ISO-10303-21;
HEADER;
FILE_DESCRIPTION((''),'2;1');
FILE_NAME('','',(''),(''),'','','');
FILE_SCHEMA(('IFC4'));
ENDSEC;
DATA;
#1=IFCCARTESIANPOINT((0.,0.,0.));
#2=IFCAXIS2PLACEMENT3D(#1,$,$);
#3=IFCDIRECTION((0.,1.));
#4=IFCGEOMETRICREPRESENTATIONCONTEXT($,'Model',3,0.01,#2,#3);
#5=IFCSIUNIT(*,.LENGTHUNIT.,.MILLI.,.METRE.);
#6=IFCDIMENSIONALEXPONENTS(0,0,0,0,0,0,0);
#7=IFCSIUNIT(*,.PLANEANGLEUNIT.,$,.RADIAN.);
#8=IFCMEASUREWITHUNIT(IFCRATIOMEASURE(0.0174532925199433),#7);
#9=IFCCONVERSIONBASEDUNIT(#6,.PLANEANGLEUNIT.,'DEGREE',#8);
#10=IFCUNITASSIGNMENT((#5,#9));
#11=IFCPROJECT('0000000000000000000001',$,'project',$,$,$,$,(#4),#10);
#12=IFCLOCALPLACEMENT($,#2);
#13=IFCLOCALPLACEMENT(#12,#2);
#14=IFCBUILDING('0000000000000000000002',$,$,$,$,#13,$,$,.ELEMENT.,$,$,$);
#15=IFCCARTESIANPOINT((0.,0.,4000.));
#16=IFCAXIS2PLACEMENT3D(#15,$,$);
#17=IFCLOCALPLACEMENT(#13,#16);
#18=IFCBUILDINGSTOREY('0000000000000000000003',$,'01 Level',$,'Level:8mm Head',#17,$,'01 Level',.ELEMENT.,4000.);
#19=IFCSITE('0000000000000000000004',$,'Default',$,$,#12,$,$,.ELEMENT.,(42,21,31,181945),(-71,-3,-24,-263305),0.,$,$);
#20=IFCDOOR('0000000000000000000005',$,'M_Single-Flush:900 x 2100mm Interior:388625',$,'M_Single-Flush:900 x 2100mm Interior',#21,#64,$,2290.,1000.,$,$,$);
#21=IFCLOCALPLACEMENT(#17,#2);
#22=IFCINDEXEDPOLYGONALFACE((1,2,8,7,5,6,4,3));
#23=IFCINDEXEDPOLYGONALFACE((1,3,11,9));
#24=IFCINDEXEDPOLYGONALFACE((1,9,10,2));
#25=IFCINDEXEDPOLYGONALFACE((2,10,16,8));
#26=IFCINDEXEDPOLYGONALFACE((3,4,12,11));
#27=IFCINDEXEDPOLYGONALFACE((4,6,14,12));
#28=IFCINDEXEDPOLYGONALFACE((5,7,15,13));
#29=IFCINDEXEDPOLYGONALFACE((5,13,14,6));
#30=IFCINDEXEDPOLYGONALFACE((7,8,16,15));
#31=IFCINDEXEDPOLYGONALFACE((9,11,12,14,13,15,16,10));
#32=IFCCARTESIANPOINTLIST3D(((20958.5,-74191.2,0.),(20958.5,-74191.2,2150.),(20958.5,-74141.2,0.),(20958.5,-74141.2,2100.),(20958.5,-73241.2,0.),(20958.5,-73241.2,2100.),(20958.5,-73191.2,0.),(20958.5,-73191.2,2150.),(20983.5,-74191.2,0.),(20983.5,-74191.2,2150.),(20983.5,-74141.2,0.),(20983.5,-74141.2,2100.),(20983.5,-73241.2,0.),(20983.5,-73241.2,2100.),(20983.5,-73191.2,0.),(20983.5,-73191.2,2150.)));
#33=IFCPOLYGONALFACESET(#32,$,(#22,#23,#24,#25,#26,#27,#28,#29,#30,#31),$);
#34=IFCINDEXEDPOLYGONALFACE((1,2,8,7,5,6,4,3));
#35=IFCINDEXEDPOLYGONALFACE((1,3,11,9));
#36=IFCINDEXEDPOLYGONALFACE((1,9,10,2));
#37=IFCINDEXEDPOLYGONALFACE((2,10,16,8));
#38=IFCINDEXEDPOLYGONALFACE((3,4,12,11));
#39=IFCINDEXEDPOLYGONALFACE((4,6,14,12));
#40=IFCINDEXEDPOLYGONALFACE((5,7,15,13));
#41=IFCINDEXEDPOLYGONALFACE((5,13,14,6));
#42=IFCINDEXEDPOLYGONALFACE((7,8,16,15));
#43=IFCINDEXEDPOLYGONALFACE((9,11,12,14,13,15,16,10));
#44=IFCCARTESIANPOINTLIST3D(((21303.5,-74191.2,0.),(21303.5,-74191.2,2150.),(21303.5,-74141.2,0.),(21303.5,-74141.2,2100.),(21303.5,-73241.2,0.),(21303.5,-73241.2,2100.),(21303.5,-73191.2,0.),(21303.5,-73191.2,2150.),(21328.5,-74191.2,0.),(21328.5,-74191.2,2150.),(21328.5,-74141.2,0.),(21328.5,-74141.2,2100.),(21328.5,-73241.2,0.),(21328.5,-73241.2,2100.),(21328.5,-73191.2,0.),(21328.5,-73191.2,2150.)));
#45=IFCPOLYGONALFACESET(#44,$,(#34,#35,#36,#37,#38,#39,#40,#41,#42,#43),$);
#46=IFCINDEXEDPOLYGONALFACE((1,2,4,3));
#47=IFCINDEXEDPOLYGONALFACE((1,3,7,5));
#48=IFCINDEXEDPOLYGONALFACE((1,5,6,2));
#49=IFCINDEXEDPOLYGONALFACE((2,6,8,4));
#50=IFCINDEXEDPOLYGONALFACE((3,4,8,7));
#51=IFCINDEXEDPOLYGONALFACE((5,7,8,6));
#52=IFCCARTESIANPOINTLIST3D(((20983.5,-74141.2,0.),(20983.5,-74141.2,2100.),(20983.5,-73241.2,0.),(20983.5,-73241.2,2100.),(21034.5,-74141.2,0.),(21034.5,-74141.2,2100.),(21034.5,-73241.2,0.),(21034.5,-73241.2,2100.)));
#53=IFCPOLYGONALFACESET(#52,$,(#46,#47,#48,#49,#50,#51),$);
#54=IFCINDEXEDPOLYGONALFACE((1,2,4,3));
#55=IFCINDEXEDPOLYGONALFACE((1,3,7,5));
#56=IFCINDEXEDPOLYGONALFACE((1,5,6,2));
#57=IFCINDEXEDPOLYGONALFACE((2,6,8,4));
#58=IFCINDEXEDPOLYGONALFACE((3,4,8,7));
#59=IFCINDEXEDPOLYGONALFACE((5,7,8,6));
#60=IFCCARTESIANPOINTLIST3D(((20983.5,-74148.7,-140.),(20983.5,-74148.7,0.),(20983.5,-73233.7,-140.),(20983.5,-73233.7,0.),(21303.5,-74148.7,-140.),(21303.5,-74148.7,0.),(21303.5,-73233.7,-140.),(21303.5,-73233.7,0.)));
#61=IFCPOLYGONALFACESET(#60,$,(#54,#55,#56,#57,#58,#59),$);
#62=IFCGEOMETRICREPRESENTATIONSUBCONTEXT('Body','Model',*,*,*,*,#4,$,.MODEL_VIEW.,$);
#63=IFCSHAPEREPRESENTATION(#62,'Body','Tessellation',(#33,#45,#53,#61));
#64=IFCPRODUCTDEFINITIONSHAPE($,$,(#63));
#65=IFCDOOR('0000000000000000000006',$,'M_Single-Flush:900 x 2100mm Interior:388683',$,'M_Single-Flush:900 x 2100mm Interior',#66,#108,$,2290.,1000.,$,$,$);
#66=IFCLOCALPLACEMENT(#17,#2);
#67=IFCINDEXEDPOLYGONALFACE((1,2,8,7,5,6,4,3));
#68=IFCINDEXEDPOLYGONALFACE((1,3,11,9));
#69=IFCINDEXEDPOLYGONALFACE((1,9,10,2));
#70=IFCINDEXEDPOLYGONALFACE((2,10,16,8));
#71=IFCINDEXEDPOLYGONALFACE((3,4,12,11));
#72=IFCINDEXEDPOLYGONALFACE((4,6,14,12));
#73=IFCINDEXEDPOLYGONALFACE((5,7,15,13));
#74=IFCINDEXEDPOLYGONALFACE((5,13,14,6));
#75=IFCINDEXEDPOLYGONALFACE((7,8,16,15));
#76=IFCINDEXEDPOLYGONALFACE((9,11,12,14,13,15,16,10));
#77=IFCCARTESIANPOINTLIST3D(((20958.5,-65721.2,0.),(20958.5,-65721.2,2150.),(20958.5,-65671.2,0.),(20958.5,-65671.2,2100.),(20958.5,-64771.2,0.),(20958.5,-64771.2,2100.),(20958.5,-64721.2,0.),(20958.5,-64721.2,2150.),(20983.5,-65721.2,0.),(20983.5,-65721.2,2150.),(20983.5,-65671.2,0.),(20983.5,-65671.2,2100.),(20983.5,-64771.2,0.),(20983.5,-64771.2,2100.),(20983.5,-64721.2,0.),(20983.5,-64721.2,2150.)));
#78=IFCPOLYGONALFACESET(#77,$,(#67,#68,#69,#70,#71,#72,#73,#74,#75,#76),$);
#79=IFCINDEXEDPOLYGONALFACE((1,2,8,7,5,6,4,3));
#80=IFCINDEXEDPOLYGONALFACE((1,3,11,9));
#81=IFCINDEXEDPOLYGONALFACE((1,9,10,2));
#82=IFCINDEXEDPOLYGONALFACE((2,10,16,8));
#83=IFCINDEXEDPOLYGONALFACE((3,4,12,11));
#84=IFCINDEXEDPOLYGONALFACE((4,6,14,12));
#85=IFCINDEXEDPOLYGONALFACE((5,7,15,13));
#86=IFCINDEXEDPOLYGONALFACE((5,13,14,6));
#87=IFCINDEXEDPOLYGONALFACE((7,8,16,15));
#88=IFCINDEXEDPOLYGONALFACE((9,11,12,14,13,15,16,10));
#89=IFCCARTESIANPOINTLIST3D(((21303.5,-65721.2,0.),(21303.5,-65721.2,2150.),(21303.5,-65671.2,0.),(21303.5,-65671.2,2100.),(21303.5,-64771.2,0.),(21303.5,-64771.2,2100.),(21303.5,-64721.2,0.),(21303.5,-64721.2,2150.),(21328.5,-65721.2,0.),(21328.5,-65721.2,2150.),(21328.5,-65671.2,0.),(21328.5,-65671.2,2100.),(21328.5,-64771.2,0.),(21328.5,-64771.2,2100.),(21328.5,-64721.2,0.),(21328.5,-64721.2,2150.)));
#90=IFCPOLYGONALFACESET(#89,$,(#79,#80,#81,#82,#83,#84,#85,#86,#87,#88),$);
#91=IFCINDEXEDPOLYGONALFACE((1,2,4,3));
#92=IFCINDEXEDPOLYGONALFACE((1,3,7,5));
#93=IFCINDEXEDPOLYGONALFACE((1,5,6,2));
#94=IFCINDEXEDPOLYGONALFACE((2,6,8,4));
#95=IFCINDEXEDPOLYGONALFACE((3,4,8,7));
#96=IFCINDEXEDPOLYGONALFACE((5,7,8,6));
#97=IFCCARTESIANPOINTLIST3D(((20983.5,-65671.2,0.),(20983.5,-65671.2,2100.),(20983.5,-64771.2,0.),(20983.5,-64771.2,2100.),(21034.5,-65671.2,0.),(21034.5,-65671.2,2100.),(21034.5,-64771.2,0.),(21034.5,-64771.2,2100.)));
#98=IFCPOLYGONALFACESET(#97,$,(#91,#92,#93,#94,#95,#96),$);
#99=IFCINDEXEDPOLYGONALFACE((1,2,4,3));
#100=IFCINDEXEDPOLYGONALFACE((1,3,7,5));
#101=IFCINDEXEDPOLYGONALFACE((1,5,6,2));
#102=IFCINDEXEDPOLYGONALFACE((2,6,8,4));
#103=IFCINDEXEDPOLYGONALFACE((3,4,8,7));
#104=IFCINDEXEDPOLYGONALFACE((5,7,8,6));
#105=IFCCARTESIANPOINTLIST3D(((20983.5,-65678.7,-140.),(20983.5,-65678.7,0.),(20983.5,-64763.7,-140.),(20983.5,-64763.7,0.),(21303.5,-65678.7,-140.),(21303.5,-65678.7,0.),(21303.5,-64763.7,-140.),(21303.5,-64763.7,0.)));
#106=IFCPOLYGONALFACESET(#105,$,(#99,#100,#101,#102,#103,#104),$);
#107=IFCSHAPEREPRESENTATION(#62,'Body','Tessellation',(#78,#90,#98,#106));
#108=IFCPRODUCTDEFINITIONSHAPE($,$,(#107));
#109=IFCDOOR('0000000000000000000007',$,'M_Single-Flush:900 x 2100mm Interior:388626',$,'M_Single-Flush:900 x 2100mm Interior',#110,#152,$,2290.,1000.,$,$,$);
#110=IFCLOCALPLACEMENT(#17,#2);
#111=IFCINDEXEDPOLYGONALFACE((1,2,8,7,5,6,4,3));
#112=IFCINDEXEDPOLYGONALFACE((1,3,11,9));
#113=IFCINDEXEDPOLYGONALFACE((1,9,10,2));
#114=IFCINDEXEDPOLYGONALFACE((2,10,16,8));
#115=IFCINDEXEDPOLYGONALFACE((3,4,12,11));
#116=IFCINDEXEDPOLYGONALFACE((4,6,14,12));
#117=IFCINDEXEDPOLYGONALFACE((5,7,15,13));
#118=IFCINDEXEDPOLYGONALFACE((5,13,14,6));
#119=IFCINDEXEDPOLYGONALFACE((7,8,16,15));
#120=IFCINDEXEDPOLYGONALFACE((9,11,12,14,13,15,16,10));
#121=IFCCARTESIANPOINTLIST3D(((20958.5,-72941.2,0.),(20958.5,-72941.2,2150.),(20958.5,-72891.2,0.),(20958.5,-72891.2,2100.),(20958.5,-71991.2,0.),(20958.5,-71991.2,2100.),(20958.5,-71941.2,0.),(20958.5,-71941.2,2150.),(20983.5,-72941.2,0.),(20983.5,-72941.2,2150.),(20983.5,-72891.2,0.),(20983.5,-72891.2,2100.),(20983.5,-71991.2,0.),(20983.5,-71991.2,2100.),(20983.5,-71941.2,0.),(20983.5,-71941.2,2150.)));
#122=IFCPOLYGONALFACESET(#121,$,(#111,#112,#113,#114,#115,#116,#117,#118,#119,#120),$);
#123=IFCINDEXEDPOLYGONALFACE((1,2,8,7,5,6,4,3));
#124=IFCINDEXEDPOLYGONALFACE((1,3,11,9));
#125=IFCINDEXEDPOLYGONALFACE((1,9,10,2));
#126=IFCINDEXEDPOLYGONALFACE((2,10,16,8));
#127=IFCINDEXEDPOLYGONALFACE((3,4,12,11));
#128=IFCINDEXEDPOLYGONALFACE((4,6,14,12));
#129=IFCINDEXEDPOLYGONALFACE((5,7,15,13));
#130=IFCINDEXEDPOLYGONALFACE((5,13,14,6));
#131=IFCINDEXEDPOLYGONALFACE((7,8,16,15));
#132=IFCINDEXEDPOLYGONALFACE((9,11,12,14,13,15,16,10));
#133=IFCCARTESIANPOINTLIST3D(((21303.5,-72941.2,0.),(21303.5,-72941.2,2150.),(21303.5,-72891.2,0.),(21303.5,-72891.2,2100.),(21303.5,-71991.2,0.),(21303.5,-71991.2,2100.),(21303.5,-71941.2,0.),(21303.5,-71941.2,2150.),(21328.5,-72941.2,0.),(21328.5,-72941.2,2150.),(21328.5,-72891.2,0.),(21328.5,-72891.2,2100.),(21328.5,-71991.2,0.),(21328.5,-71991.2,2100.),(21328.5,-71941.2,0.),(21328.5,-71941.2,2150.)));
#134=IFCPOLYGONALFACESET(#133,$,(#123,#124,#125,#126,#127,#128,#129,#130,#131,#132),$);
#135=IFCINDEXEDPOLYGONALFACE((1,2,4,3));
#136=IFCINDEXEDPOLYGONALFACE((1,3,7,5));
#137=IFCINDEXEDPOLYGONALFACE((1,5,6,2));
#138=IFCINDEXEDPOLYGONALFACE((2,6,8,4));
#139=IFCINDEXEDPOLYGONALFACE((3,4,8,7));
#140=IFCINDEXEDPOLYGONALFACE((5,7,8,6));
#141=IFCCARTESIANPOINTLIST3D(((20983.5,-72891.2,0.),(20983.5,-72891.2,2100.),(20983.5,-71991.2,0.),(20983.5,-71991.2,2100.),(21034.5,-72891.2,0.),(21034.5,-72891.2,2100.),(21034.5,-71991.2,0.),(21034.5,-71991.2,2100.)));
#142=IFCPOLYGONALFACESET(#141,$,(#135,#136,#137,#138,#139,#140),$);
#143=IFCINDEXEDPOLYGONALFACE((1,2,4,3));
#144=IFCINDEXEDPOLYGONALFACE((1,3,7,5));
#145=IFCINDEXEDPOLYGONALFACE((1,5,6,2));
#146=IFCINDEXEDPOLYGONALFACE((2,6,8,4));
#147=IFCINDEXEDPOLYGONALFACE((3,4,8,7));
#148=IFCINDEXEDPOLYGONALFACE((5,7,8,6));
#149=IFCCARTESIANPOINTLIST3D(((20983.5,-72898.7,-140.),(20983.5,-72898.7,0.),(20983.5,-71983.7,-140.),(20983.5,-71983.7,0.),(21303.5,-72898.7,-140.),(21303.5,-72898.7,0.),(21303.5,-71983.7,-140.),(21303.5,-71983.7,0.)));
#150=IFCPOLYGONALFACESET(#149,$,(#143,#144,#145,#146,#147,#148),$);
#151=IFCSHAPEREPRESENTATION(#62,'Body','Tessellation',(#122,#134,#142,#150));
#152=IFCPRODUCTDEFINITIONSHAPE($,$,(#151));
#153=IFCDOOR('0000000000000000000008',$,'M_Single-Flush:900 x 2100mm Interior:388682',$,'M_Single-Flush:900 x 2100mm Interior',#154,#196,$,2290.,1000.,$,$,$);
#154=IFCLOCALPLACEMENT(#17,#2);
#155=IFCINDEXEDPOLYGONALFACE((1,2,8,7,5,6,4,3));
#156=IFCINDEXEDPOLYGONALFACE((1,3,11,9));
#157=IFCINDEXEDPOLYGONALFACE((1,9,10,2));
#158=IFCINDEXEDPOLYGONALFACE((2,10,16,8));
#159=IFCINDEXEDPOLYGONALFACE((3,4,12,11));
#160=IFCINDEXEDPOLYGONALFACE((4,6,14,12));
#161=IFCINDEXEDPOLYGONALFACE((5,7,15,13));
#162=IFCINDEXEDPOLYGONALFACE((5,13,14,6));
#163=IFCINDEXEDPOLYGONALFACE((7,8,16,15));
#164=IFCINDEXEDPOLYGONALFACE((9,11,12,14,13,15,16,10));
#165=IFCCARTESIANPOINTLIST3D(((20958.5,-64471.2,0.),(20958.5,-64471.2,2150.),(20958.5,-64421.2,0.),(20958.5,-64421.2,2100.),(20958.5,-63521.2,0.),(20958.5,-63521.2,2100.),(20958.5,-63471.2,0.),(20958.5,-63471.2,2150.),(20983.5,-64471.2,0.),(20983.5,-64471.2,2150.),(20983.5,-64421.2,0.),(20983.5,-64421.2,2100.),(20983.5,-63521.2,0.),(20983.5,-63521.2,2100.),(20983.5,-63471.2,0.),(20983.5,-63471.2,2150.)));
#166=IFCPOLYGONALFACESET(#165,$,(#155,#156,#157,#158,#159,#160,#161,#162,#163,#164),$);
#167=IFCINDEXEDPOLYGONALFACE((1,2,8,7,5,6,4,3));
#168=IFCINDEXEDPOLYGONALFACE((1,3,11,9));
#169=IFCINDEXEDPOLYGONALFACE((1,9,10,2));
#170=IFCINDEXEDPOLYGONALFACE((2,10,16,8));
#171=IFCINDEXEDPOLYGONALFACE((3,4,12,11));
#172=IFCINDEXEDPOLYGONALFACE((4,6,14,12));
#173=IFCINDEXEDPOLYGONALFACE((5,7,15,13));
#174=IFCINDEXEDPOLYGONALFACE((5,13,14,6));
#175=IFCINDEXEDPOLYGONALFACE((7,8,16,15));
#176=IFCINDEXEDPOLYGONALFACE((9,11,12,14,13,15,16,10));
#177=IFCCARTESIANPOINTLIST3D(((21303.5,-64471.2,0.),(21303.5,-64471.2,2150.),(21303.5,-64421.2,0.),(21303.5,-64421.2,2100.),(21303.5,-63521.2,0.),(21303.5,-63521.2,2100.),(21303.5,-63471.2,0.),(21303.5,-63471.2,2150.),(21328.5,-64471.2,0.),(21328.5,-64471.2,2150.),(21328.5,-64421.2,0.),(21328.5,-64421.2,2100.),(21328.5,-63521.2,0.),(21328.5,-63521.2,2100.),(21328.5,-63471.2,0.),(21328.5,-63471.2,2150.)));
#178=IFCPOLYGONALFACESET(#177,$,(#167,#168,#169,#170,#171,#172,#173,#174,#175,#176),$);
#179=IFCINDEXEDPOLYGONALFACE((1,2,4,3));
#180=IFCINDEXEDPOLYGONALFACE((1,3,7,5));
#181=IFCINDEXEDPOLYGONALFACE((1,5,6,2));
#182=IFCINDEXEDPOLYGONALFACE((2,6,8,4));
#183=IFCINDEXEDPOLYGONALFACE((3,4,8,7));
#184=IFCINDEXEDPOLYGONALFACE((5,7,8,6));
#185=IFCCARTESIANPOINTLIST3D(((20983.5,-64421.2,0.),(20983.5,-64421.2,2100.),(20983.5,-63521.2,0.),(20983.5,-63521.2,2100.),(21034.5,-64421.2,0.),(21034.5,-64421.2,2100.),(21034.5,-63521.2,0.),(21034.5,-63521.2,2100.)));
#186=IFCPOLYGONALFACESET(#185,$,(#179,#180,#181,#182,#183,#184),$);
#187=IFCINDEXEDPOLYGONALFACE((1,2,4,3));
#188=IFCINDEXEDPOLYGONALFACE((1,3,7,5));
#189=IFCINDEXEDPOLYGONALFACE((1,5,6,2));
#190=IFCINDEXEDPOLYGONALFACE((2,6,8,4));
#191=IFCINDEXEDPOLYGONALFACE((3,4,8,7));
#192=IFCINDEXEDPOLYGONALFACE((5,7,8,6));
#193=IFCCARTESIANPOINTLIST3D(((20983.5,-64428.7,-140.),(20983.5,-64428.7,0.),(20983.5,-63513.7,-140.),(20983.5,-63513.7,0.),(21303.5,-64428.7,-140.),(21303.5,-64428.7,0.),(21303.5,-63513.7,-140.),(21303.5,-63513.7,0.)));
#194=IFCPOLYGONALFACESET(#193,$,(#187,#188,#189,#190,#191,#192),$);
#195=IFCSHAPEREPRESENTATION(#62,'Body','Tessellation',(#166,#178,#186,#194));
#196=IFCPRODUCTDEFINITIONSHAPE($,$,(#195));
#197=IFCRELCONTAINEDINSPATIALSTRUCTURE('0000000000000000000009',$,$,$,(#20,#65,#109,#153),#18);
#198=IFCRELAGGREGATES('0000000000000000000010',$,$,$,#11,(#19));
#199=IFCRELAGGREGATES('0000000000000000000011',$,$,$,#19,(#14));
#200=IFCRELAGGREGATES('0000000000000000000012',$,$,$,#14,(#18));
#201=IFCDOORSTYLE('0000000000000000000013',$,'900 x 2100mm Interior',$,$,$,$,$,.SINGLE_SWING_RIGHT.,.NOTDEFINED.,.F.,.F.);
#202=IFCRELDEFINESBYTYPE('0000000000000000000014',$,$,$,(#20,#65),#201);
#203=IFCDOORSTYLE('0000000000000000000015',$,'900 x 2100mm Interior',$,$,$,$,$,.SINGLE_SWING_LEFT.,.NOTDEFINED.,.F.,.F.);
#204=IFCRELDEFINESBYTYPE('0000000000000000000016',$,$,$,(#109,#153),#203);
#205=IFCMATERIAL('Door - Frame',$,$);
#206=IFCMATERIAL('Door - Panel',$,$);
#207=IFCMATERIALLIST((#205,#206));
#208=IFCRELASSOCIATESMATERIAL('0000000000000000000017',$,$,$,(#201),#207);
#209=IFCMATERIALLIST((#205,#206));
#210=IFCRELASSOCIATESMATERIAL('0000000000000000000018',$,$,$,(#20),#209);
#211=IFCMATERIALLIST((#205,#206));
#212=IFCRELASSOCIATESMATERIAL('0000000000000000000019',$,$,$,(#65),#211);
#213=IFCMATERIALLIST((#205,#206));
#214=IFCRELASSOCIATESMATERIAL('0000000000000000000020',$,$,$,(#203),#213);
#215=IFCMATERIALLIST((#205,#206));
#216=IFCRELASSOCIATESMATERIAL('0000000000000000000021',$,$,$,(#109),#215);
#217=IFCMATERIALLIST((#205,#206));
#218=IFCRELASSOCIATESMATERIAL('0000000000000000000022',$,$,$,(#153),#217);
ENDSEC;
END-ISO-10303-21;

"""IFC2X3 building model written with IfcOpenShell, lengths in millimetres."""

from ifc_helpers import new_model, entity, si_unit, converted_unit, direction, frame, frame_2d, origin, origin_2d_with_axis, place, context, subcontext, project, spatial, polyline, rectangle, outline, extrude, source, transform, mapped, material, material_list, type_object, type_shapes, element, save


model = new_model("IFC2X3")

# Units and contexts
model_context = context("Model", 3, precision=0.01, world=origin(), true_north=direction((0.0, 1.0)))
body_context = subcontext(model_context, "Body", "Model", "MODEL_VIEW")
ifc_project = project(units=[si_unit("LENGTHUNIT", "METRE", prefix="MILLI"), converted_unit("PLANEANGLEUNIT", "DEGREE", entity("IfcRatioMeasure", 0.0174532925199433), si_unit("PLANEANGLEUNIT", "RADIAN"), dimensions=[0, 0, 0, 0, 0, 0, 0])], contexts=[model_context])

# Site, building, storey
site_placement = place(None, origin())
site = spatial("IfcSite", under=ifc_project, at=site_placement, Name="Default", CompositionType="ELEMENT", RefLatitude=(42, 21, 31, 181945), RefLongitude=(-71, -3, -24, -263305), RefElevation=0.0)
building_placement = place(site_placement, origin())
building = spatial("IfcBuilding", under=site, at=building_placement, CompositionType="ELEMENT")
storey_placement = place(building_placement, frame((0.0, 0.0, 4000.0)))
storey = spatial("IfcBuildingStorey", under=building, at=storey_placement, Name="01 Level", ObjectType="Level:8mm Head", LongName="01 Level", CompositionType="ELEMENT", Elevation=4000.0)

# Doors
ifc_material_1 = material(Name="Door - Frame")
ifc_material_2 = material(Name="Door - Panel")
ifc_material_list_1 = material_list([ifc_material_1, ifc_material_2])
ifc_material_list_2 = material_list([ifc_material_1, ifc_material_2])
door_style_1 = type_object("IfcDoorStyle", Name="900 x 2100mm Interior", ConstructionType="NOTDEFINED", OperationType="SINGLE_SWING_RIGHT", ParameterTakesPrecedence=False, Sizeable=False, material=ifc_material_list_2)
shared_shape_1 = source(origin(), body_context, "Body", "SweptSolid", [
    extrude(outline(polyline([(-500.0, -1087.5), (500.0, -1087.5), (500.0, 1062.5), (450.0, 1062.5), (450.0, -1037.5), (-450.0, -1037.5), (-450.0, 1062.5), (-500.0, 1062.5), (-500.0, -1087.5)])), frame((450.0, 320.0, 1202.5), z_axis=(0.0, 1.0, 0.0), x_axis=(1.0, 0.0, 0.0)), (0.0, 0.0, 1.0), 25.0),
    extrude(outline(polyline([(-1087.5, -500.0), (1062.5, -500.0), (1062.5, -450.0), (-1037.5, -450.0), (-1037.5, 450.0), (1062.5, 450.0), (1062.5, 500.0), (-1087.5, 500.0), (-1087.5, -500.0)])), frame((450.0, -25.0, 1202.5), z_axis=(0.0, 1.0, 0.0), x_axis=(0.0, 0.0, -1.0)), (0.0, 0.0, 1.0), 25.0),
    extrude(rectangle(XDim=51.0, YDim=900.0, at=frame_2d((0.0, 0.0), x_axis=(1.0, 0.0))), frame((450.0, 294.5, 140.0), z_axis=(0.0, 0.0, 1.0), x_axis=(0.0, 1.0, 0.0)), (0.0, 0.0, 1.0), 2100.0),
    extrude(rectangle(XDim=915.0, YDim=320.0, at=origin_2d_with_axis()), frame((450.0, 160.0, 0.0), z_axis=(0.0, 0.0, 1.0), x_axis=(-1.0, 0.0, 0.0)), (0.0, 0.0, 1.0), 140.0),
])
type_shapes(door_style_1, [shared_shape_1])
door_1_placement = place(storey_placement, frame((21303.5, -74141.2, -140.0), z_axis=(0.0, 0.0, 1.0), x_axis=(0.0, 1.0, 0.0)))
element("IfcDoor", 1, at=door_1_placement, inside=storey, type_object=door_style_1, material=ifc_material_list_1, Name="M_Single-Flush:900 x 2100mm Interior:388625", ObjectType="M_Single-Flush:900 x 2100mm Interior", OverallHeight=2290.0, OverallWidth=1000.0, context=body_context, shape_type="MappedRepresentation", body=[
    mapped(shared_shape_1, transform((0.0, 0.0, 0.0), scale=1.0)),
])
ifc_material_list_3 = material_list([ifc_material_1, ifc_material_2])
door_2_placement = place(storey_placement, frame((21303.5, -65671.2, -140.0), z_axis=(0.0, 0.0, 1.0), x_axis=(0.0, 1.0, 0.0)))
element("IfcDoor", 2, at=door_2_placement, inside=storey, type_object=door_style_1, material=ifc_material_list_3, Name="M_Single-Flush:900 x 2100mm Interior:388683", ObjectType="M_Single-Flush:900 x 2100mm Interior", OverallHeight=2290.0, OverallWidth=1000.0, context=body_context, shape_type="MappedRepresentation", body=[
    mapped(shared_shape_1, transform((0.0, 0.0, 0.0), scale=1.0)),
])
ifc_material_list_4 = material_list([ifc_material_1, ifc_material_2])
ifc_material_list_5 = material_list([ifc_material_1, ifc_material_2])
door_style_2 = type_object("IfcDoorStyle", Name="900 x 2100mm Interior", ConstructionType="NOTDEFINED", OperationType="SINGLE_SWING_LEFT", ParameterTakesPrecedence=False, Sizeable=False, material=ifc_material_list_5)
shared_shape_2 = source(origin(), body_context, "Body", "SweptSolid", [
    extrude(outline(polyline([(-500.0, -1087.5), (500.0, -1087.5), (500.0, 1062.5), (450.0, 1062.5), (450.0, -1037.5), (-450.0, -1037.5), (-450.0, 1062.5), (-500.0, 1062.5), (-500.0, -1087.5)])), frame((450.0, 345.0, 1202.5), z_axis=(0.0, -1.0, 0.0), x_axis=(-1.0, 0.0, 0.0)), (0.0, 0.0, 1.0), 25.0),
    extrude(outline(polyline([(-1087.5, -500.0), (1062.5, -500.0), (1062.5, -450.0), (-1037.5, -450.0), (-1037.5, 450.0), (1062.5, 450.0), (1062.5, 500.0), (-1087.5, 500.0), (-1087.5, -500.0)])), frame((450.0, 0.0, 1202.5), z_axis=(0.0, -1.0, 0.0), x_axis=(0.0, 0.0, -1.0)), (0.0, 0.0, 1.0), 25.0),
    extrude(rectangle(XDim=900.0, YDim=51.0, at=origin_2d_with_axis()), frame((450.0, 294.5, 140.0)), (0.0, 0.0, 1.0), 2100.0),
    extrude(rectangle(XDim=320.0, YDim=915.0, at=origin_2d_with_axis()), frame((450.0, 160.0, 0.0), z_axis=(0.0, 0.0, 1.0), x_axis=(0.0, -1.0, 0.0)), (0.0, 0.0, 1.0), 140.0),
])
type_shapes(door_style_2, [shared_shape_2])
door_3_placement = place(storey_placement, frame((21303.5, -72891.2, -140.0), z_axis=(0.0, 0.0, 1.0), x_axis=(0.0, 1.0, 0.0)))
element("IfcDoor", 3, at=door_3_placement, inside=storey, type_object=door_style_2, material=ifc_material_list_4, Name="M_Single-Flush:900 x 2100mm Interior:388626", ObjectType="M_Single-Flush:900 x 2100mm Interior", OverallHeight=2290.0, OverallWidth=1000.0, context=body_context, shape_type="MappedRepresentation", body=[
    mapped(shared_shape_2, transform((0.0, 0.0, 0.0), scale=1.0)),
])
ifc_material_list_6 = material_list([ifc_material_1, ifc_material_2])
door_4_placement = place(storey_placement, frame((21303.5, -64421.2, -140.0), z_axis=(0.0, 0.0, 1.0), x_axis=(0.0, 1.0, 0.0)))
element("IfcDoor", 4, at=door_4_placement, inside=storey, type_object=door_style_2, material=ifc_material_list_6, Name="M_Single-Flush:900 x 2100mm Interior:388682", ObjectType="M_Single-Flush:900 x 2100mm Interior", OverallHeight=2290.0, OverallWidth=1000.0, context=body_context, shape_type="MappedRepresentation", body=[
    mapped(shared_shape_2, transform((0.0, 0.0, 0.0), scale=1.0)),
])

save(model, "model.ifc")
